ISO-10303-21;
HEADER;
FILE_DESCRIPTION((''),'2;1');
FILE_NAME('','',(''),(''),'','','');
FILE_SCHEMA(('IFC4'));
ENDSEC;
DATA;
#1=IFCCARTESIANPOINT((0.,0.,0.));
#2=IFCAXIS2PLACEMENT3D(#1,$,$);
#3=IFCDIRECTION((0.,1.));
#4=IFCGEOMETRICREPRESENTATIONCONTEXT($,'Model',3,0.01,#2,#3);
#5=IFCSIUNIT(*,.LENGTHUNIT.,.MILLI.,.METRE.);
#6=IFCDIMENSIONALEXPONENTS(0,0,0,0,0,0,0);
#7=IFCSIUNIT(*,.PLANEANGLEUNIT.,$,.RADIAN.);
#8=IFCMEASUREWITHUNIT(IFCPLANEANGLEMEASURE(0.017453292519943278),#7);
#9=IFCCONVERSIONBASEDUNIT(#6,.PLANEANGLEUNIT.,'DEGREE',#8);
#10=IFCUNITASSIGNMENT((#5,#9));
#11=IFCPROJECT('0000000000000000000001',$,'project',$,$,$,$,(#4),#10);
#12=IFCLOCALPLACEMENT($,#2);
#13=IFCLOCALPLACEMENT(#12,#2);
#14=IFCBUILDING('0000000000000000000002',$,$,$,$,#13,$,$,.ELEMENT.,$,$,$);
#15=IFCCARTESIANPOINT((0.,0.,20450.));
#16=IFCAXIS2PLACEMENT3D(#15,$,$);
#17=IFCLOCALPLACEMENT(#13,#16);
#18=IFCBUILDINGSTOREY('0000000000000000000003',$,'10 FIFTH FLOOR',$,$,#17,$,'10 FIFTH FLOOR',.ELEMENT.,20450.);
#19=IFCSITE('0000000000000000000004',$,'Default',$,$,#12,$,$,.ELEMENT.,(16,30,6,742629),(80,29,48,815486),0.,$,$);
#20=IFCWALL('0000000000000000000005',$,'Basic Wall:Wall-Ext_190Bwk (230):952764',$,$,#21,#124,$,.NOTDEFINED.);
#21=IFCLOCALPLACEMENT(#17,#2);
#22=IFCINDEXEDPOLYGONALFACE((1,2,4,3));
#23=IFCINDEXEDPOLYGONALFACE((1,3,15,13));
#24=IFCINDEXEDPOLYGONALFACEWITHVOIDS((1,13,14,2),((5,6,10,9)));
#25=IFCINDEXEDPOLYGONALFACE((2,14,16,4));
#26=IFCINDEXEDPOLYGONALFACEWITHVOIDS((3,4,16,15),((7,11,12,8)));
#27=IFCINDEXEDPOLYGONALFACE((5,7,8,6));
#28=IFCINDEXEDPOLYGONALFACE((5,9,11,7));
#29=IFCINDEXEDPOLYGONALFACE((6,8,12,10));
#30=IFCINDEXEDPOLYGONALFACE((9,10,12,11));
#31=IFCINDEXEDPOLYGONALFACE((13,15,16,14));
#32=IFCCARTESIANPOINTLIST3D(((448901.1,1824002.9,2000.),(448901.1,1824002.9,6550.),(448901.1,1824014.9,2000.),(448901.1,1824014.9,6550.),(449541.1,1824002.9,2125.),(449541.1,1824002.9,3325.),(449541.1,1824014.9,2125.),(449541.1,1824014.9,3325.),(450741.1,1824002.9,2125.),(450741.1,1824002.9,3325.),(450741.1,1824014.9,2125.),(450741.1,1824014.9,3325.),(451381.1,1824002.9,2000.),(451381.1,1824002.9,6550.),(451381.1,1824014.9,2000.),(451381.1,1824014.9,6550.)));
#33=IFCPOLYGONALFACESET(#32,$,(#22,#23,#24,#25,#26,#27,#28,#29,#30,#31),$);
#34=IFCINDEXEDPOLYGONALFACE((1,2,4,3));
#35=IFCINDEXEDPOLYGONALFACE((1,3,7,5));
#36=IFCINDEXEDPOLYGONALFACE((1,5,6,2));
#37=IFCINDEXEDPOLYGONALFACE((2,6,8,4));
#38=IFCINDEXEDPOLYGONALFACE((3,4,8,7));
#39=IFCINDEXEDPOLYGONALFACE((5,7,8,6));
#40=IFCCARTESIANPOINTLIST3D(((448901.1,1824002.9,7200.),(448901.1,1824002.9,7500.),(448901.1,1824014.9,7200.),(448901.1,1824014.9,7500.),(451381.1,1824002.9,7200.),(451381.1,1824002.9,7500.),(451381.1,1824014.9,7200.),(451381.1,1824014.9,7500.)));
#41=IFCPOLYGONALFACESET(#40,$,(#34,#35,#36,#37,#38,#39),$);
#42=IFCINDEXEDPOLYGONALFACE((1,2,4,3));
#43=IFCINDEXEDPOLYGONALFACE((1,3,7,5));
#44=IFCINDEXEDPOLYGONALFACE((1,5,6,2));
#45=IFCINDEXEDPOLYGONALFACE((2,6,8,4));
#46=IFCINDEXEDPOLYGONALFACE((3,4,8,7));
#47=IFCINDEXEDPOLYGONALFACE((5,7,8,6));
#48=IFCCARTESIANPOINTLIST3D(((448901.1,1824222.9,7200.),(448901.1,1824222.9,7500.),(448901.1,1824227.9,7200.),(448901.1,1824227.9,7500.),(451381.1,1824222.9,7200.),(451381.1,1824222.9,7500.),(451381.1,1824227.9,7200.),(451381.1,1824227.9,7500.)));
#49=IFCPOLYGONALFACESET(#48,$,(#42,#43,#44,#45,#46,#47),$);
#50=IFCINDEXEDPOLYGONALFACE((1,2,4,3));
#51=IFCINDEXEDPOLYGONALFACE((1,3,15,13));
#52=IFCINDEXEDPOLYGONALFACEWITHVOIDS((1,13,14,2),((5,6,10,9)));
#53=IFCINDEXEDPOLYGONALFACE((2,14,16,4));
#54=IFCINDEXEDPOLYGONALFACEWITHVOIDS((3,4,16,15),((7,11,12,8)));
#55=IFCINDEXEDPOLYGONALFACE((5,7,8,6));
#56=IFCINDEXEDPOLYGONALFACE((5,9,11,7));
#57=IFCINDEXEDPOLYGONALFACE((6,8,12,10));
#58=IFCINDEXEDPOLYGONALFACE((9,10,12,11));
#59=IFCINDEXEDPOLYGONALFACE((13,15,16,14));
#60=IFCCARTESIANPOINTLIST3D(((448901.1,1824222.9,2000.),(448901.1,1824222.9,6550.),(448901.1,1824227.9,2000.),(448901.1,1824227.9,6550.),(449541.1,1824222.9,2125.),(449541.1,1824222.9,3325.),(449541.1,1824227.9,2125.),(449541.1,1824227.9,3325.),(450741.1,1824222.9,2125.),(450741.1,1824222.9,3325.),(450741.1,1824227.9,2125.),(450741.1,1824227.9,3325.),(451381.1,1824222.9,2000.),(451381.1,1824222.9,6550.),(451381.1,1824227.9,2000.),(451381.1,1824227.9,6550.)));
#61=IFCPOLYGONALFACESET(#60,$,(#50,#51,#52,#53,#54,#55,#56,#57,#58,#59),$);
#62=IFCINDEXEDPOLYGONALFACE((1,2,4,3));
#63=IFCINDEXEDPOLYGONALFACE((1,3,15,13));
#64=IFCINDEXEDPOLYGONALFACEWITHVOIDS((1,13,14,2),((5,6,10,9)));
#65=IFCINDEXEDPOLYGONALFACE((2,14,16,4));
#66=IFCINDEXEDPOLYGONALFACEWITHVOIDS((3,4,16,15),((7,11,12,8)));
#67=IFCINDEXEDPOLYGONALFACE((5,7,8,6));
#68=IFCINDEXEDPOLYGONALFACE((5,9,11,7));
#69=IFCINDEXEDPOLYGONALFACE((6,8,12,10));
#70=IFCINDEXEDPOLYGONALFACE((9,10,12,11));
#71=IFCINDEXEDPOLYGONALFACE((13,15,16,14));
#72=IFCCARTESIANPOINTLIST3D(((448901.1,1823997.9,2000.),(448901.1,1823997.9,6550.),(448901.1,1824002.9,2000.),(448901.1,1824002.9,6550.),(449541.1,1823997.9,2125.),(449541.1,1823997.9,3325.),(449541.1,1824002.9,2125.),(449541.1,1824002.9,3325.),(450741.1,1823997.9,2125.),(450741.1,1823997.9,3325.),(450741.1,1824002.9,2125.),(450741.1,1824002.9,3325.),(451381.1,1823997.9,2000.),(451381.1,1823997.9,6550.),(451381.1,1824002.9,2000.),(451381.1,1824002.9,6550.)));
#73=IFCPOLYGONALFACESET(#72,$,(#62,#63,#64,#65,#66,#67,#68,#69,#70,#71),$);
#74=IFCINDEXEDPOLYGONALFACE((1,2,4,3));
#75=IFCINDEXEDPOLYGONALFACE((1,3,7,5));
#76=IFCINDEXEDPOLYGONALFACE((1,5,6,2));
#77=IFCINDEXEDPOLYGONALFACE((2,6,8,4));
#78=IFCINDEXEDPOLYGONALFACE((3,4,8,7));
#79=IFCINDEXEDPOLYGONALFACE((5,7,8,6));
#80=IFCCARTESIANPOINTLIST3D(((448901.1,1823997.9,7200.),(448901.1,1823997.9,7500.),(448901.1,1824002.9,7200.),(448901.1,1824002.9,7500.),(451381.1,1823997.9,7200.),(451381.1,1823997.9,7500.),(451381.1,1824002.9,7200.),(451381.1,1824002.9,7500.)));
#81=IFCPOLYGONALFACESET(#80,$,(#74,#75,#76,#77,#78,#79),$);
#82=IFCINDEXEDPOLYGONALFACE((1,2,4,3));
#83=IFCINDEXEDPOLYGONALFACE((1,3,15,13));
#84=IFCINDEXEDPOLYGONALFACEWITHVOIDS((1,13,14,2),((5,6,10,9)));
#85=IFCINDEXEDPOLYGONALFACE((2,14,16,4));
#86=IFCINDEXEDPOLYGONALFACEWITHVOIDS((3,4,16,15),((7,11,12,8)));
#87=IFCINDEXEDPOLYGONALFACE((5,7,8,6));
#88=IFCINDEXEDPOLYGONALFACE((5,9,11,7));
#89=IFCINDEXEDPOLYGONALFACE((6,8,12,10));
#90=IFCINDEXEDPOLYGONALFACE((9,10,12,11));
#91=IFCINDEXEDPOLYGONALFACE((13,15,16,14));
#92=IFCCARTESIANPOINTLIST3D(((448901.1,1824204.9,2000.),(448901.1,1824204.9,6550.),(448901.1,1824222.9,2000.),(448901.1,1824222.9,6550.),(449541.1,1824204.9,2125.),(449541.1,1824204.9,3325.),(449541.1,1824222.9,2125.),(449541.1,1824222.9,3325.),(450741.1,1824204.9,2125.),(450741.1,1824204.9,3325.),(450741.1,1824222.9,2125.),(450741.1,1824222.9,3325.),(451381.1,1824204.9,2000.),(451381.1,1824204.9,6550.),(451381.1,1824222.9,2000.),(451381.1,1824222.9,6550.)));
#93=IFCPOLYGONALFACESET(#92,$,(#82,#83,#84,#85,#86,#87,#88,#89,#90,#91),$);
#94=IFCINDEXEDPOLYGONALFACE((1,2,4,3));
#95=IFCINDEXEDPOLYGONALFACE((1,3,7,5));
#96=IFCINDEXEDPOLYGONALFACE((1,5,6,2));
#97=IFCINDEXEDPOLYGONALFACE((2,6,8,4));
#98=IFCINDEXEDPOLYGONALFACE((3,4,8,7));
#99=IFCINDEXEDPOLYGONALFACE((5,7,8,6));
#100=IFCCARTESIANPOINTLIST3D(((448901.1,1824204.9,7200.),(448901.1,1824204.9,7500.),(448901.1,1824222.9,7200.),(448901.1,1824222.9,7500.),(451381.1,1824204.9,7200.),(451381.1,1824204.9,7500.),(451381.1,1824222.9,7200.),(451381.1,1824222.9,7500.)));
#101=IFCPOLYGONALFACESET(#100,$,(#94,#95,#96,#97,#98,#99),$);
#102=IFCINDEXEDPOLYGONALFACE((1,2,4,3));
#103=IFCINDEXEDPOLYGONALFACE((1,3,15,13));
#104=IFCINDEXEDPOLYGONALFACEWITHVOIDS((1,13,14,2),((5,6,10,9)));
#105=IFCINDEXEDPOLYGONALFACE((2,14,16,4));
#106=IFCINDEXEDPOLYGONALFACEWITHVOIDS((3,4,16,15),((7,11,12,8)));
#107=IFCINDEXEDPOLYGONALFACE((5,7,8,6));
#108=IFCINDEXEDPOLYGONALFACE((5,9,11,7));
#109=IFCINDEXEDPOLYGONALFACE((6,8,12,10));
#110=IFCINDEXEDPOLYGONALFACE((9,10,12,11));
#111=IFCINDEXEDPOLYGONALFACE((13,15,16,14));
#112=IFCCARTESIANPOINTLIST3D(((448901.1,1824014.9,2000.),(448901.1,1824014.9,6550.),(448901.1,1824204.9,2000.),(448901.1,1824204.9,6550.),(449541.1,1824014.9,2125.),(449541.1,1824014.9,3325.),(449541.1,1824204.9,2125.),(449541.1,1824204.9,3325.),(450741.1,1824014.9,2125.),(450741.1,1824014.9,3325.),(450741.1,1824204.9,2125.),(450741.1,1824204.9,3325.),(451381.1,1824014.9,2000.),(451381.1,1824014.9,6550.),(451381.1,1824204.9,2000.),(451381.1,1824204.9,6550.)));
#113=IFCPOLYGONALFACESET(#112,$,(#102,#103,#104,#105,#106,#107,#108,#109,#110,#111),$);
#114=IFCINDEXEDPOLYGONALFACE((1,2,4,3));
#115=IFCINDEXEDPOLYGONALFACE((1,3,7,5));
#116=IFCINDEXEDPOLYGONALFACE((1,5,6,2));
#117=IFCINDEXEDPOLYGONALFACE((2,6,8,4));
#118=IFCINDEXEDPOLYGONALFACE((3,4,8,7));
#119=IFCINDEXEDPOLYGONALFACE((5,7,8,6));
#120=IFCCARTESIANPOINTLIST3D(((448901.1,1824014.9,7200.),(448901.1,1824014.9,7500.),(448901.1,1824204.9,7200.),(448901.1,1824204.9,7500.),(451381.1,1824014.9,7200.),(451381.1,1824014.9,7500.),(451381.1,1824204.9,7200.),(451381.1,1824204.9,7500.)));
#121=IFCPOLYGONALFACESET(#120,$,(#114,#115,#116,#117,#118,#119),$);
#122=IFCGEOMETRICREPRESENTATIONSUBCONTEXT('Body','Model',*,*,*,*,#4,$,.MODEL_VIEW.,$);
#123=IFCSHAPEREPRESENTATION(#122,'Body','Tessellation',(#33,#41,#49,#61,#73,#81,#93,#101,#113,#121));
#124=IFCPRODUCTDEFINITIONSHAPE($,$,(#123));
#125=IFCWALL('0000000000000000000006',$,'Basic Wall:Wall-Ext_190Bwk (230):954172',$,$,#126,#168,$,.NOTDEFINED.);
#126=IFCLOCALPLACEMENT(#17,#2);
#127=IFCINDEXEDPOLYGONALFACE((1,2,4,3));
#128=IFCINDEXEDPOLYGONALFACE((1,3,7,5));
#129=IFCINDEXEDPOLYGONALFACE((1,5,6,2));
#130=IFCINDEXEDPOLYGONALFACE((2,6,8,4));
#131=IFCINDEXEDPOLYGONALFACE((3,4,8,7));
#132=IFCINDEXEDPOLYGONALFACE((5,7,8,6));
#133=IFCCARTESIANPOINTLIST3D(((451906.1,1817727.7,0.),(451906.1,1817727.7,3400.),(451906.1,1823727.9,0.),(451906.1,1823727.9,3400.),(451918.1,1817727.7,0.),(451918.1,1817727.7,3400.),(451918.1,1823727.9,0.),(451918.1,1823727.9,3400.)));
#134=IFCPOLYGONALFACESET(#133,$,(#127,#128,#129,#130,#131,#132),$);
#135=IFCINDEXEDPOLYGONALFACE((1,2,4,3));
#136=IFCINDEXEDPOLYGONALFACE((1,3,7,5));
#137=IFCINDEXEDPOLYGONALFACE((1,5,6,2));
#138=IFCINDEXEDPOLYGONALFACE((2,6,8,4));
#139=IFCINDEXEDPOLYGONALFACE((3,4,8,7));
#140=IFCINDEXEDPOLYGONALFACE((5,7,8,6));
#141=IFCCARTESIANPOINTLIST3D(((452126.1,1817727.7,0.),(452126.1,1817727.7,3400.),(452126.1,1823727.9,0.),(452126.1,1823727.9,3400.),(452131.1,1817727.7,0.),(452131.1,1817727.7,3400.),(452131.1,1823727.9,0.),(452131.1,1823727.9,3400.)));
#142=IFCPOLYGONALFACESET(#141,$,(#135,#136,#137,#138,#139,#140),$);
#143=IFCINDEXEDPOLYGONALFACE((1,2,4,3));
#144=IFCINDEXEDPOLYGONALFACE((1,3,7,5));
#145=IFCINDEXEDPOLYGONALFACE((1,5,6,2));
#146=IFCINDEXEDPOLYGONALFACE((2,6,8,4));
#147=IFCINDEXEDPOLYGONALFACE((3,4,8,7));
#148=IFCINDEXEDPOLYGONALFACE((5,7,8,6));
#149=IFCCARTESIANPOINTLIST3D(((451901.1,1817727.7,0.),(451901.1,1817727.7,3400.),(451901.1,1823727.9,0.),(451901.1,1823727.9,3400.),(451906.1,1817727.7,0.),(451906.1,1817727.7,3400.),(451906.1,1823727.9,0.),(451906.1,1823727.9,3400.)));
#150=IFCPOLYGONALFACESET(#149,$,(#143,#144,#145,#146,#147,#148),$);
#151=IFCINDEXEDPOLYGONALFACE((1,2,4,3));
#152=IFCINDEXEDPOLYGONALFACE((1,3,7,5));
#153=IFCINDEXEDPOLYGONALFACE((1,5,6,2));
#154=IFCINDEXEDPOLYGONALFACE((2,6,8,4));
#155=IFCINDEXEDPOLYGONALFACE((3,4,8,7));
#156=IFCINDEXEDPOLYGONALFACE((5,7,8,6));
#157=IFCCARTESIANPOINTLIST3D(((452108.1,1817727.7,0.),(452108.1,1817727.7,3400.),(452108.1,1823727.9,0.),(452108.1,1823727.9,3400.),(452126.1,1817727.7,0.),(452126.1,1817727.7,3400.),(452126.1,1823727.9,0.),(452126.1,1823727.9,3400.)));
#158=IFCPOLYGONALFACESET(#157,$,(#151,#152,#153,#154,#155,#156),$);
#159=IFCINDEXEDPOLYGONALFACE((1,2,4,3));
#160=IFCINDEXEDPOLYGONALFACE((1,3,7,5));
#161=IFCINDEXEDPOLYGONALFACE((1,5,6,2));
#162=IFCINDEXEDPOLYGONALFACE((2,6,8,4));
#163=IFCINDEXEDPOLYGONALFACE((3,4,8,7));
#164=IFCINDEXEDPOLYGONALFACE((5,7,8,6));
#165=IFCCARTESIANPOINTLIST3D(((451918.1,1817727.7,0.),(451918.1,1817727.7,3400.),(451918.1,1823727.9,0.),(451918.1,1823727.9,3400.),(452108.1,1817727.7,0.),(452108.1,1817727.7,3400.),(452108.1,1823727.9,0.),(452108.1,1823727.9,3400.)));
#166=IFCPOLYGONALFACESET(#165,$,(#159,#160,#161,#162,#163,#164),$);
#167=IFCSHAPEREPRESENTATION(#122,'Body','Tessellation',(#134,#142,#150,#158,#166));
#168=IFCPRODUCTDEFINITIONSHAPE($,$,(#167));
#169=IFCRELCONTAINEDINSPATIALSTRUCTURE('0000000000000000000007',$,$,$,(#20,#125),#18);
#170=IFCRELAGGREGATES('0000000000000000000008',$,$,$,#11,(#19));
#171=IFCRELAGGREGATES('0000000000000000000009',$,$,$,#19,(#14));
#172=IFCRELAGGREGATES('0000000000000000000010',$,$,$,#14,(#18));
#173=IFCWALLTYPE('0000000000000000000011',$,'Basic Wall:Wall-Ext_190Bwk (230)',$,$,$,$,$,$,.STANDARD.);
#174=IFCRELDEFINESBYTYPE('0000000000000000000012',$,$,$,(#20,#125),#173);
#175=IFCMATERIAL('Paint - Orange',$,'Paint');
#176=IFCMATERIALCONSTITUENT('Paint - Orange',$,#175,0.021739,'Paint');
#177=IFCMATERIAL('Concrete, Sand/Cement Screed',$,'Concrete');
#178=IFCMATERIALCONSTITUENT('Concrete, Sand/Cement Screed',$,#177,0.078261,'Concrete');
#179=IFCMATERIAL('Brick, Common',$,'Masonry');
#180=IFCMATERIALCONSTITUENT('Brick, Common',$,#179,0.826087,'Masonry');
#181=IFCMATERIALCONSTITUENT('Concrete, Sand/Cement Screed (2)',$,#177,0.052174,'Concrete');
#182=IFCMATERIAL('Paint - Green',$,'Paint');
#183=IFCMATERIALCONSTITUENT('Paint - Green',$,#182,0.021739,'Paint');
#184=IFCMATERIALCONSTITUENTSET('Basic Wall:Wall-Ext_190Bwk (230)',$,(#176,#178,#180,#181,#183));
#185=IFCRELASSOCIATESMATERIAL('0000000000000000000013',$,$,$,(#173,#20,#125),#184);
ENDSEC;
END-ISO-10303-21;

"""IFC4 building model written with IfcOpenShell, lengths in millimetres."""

from ifc_helpers import new_model, entity, si_unit, converted_unit, direction, frame, origin, place, context, subcontext, project, spatial, indexed_curve, outline, extrude, material, constituent, constituent_set, type_object, element, save


model = new_model("IFC4")

# Units and contexts
model_context = context("Model", 3, precision=0.01, world=origin(), true_north=direction((0.0, 1.0)))
body_context = subcontext(model_context, "Body", "Model", "MODEL_VIEW")
ifc_project = project(units=[si_unit("LENGTHUNIT", "METRE", prefix="MILLI"), converted_unit("PLANEANGLEUNIT", "DEGREE", entity("IfcPlaneAngleMeasure", 0.017453292519943278), si_unit("PLANEANGLEUNIT", "RADIAN"), dimensions=[0, 0, 0, 0, 0, 0, 0])], contexts=[model_context])

# Site, building, storey
site_placement = place(None, origin())
site = spatial("IfcSite", under=ifc_project, at=site_placement, Name="Default", CompositionType="ELEMENT", RefLatitude=(16, 30, 6, 742629), RefLongitude=(80, 29, 48, 815486), RefElevation=0.0)
building_placement = place(site_placement, origin())
building = spatial("IfcBuilding", under=site, at=building_placement, CompositionType="ELEMENT")
storey_placement = place(building_placement, frame((0.0, 0.0, 20450.0)))
storey = spatial("IfcBuildingStorey", under=building, at=storey_placement, Name="10 FIFTH FLOOR", LongName="10 FIFTH FLOOR", CompositionType="ELEMENT", Elevation=20450.0)

# Shared definitions
ifc_material_1 = material(Name="Concrete, Sand/Cement Screed", Category="Concrete")
ifc_material_2 = material(Name="Brick, Common", Category="Masonry")

# Wall, opening
ifc_material_3 = material(Name="Paint - Orange", Category="Paint")
ifc_constituent_1 = constituent(ifc_material_3, Name="Paint - Orange", Category="Paint", fraction=0.021739)
ifc_constituent_2 = constituent(ifc_material_1, Name="Concrete, Sand/Cement Screed", Category="Concrete", fraction=0.078261)
ifc_constituent_3 = constituent(ifc_material_2, Name="Brick, Common", Category="Masonry", fraction=0.826087)
ifc_constituent_4 = constituent(ifc_material_1, Name="Concrete, Sand/Cement Screed (2)", Category="Concrete", fraction=0.052174)
ifc_material_4 = material(Name="Paint - Green", Category="Paint")
ifc_constituent_5 = constituent(ifc_material_4, Name="Paint - Green", Category="Paint", fraction=0.021739)
ifc_constituent_set_1 = constituent_set(constituents=[ifc_constituent_1, ifc_constituent_2, ifc_constituent_3, ifc_constituent_4, ifc_constituent_5], Name="Basic Wall:Wall-Ext_190Bwk (230)")
wall_type_1 = type_object("IfcWallType", Name="Basic Wall:Wall-Ext_190Bwk (230)", PredefinedType="STANDARD", material=ifc_constituent_set_1)
wall_1_placement = place(storey_placement, frame((448901.1, 1824112.9, 2000.0)))
wall_1 = element("IfcWall", 1, at=wall_1_placement, inside=storey, type_object=wall_type_1, material=ifc_constituent_set_1, Name="Basic Wall:Wall-Ext_190Bwk (230):952764", PredefinedType="NOTDEFINED", context=body_context, shape_type="SweptSolid", body=[
    extrude(outline(indexed_curve([(-2275.0, -1240.0), (2275.0, -1240.0), (2275.0, 1240.0), (-2275.0, 1240.0), (-2275.0, -1240.0)], self_intersect=False), holes=[indexed_curve([(-2150.0, -600.0), (-2150.0, 600.0), (-950.0, 600.0), (-950.0, -600.0), (-2150.0, -600.0)], self_intersect=False)]), frame((1240.0, -110.0, 2275.0), z_axis=(0.0, 1.0, 0.0), x_axis=(0.0, 0.0, 1.0)), (0.0, 0.0, 1.0), 12.0),
    extrude(outline(indexed_curve([(-1240.0, -6.0), (1240.0, -6.0), (1240.0, 6.0), (-1240.0, 6.0), (-1240.0, -6.0)], self_intersect=False)), frame((1240.0, -104.0, 5200.0)), (0.0, 0.0, 1.0), 300.0),
    extrude(outline(indexed_curve([(-2.5, -1240.0), (2.5, -1240.0), (2.5, 1240.0), (-2.5, 1240.0), (-2.5, -1240.0)], self_intersect=False)), frame((1240.0, 112.5, 5200.0), z_axis=(0.0, 0.0, 1.0), x_axis=(0.0, -1.0, 0.0)), (0.0, 0.0, 1.0), 300.0),
    extrude(outline(indexed_curve([(-2275.0, -1240.0), (2275.0, -1240.0), (2275.0, 1240.0), (-2275.0, 1240.0), (-2275.0, -1240.0)], self_intersect=False), holes=[indexed_curve([(-2150.0, -600.0), (-2150.0, 600.0), (-950.0, 600.0), (-950.0, -600.0), (-2150.0, -600.0)], self_intersect=False)]), frame((1240.0, 110.0, 2275.0), z_axis=(0.0, 1.0, 0.0), x_axis=(0.0, 0.0, 1.0)), (0.0, 0.0, 1.0), 5.0),
    extrude(outline(indexed_curve([(-2275.0, -1240.0), (2275.0, -1240.0), (2275.0, 1240.0), (-2275.0, 1240.0), (-2275.0, -1240.0)], self_intersect=False), holes=[indexed_curve([(-950.0, -600.0), (-2150.0, -600.0), (-2150.0, 600.0), (-950.0, 600.0), (-950.0, -600.0)], self_intersect=False)]), frame((1240.0, -115.0, 2275.0), z_axis=(0.0, 1.0, 0.0), x_axis=(0.0, 0.0, 1.0)), (0.0, 0.0, 1.0), 5.0),
    extrude(outline(indexed_curve([(-2.5, -1240.0), (2.5, -1240.0), (2.5, 1240.0), (-2.5, 1240.0), (-2.5, -1240.0)], self_intersect=False)), frame((1240.0, -112.5, 5200.0), z_axis=(0.0, 0.0, 1.0), x_axis=(0.0, 1.0, 0.0)), (0.0, 0.0, 1.0), 300.0),
    extrude(outline(indexed_curve([(-2275.0, -1240.0), (2275.0, -1240.0), (2275.0, 1240.0), (-2275.0, 1240.0), (-2275.0, -1240.0)], self_intersect=False), holes=[indexed_curve([(-2150.0, -600.0), (-2150.0, 600.0), (-950.0, 600.0), (-950.0, -600.0), (-2150.0, -600.0)], self_intersect=False)]), frame((1240.0, 92.0, 2275.0), z_axis=(0.0, 1.0, 0.0), x_axis=(0.0, 0.0, 1.0)), (0.0, 0.0, 1.0), 18.0),
    extrude(outline(indexed_curve([(-1240.0, -9.0), (1240.0, -9.0), (1240.0, 9.0), (-1240.0, 9.0), (-1240.0, -9.0)], self_intersect=False)), frame((1240.0, 101.0, 5200.0)), (0.0, 0.0, 1.0), 300.0),
    extrude(outline(indexed_curve([(-2275.0, -1240.0), (2275.0, -1240.0), (2275.0, 1240.0), (-2275.0, 1240.0), (-2275.0, -1240.0)], self_intersect=False), holes=[indexed_curve([(-2150.0, -600.0), (-2150.0, 600.0), (-950.0, 600.0), (-950.0, -600.0), (-2150.0, -600.0)], self_intersect=False)]), frame((1240.0, -98.0, 2275.0), z_axis=(0.0, 1.0, 0.0), x_axis=(0.0, 0.0, 1.0)), (0.0, 0.0, 1.0), 190.0),
    extrude(outline(indexed_curve([(-1240.0, -95.0), (1240.0, -95.0), (1240.0, 95.0), (-1240.0, 95.0), (-1240.0, -95.0)], self_intersect=False)), frame((1240.0, -3.0, 5200.0)), (0.0, 0.0, 1.0), 300.0),
])
opening_1_placement = place(wall_1_placement, frame((640.0, -115.0, 125.0)))
element("IfcOpeningElement", 2, at=opening_1_placement, cuts=wall_1, PredefinedType="OPENING", context=body_context, shape_type="SweptSolid", body=[
    extrude(outline(indexed_curve([(1200.0, 0.0), (1200.0, 1200.0), (0.0, 1200.0), (0.0, 0.0), (1200.0, 0.0)], self_intersect=False)), frame((0.0, 0.0, 0.0), z_axis=(0.0, 1.0, 0.0), x_axis=(0.0, 0.0, 1.0)), (0.0, 0.0, 1.0), 230.0),
])

# Wall
wall_2_placement = place(storey_placement, frame((452016.1, 1823727.9, 0.0), z_axis=(0.0, 0.0, 1.0), x_axis=(0.0, -1.0, 0.0)))
element("IfcWall", 3, at=wall_2_placement, inside=storey, type_object=wall_type_1, material=ifc_constituent_set_1, Name="Basic Wall:Wall-Ext_190Bwk (230):954172", PredefinedType="NOTDEFINED", context=body_context, shape_type="SweptSolid", body=[
    extrude(outline(indexed_curve([(-3000.1, -6.0), (3000.1, -6.0), (3000.1, 6.0), (-3000.1, 6.0), (-3000.1, -6.0)], self_intersect=False)), frame((3000.1, -104.0, 0.0)), (0.0, 0.0, 1.0), 3400.0),
    extrude(outline(indexed_curve([(-2.5, -3000.1), (2.5, -3000.1), (2.5, 3000.1), (-2.5, 3000.1), (-2.5, -3000.1)], self_intersect=False)), frame((3000.1, 112.5, 0.0), z_axis=(0.0, 0.0, 1.0), x_axis=(0.0, -1.0, 0.0)), (0.0, 0.0, 1.0), 3400.0),
    extrude(outline(indexed_curve([(-2.5, -3000.1), (2.5, -3000.1), (2.5, 3000.1), (-2.5, 3000.1), (-2.5, -3000.1)], self_intersect=False)), frame((3000.1, -112.5, 0.0), z_axis=(0.0, 0.0, 1.0), x_axis=(0.0, 1.0, 0.0)), (0.0, 0.0, 1.0), 3400.0),
    extrude(outline(indexed_curve([(-3000.1, -9.0), (3000.1, -9.0), (3000.1, 9.0), (-3000.1, 9.0), (-3000.1, -9.0)], self_intersect=False)), frame((3000.1, 101.0, 0.0)), (0.0, 0.0, 1.0), 3400.0),
    extrude(outline(indexed_curve([(-3000.1, -95.0), (3000.1, -95.0), (3000.1, 95.0), (-3000.1, 95.0), (-3000.1, -95.0)], self_intersect=False)), frame((3000.1, -3.0, 0.0)), (0.0, 0.0, 1.0), 3400.0),
])

save(model, "model.ifc")
